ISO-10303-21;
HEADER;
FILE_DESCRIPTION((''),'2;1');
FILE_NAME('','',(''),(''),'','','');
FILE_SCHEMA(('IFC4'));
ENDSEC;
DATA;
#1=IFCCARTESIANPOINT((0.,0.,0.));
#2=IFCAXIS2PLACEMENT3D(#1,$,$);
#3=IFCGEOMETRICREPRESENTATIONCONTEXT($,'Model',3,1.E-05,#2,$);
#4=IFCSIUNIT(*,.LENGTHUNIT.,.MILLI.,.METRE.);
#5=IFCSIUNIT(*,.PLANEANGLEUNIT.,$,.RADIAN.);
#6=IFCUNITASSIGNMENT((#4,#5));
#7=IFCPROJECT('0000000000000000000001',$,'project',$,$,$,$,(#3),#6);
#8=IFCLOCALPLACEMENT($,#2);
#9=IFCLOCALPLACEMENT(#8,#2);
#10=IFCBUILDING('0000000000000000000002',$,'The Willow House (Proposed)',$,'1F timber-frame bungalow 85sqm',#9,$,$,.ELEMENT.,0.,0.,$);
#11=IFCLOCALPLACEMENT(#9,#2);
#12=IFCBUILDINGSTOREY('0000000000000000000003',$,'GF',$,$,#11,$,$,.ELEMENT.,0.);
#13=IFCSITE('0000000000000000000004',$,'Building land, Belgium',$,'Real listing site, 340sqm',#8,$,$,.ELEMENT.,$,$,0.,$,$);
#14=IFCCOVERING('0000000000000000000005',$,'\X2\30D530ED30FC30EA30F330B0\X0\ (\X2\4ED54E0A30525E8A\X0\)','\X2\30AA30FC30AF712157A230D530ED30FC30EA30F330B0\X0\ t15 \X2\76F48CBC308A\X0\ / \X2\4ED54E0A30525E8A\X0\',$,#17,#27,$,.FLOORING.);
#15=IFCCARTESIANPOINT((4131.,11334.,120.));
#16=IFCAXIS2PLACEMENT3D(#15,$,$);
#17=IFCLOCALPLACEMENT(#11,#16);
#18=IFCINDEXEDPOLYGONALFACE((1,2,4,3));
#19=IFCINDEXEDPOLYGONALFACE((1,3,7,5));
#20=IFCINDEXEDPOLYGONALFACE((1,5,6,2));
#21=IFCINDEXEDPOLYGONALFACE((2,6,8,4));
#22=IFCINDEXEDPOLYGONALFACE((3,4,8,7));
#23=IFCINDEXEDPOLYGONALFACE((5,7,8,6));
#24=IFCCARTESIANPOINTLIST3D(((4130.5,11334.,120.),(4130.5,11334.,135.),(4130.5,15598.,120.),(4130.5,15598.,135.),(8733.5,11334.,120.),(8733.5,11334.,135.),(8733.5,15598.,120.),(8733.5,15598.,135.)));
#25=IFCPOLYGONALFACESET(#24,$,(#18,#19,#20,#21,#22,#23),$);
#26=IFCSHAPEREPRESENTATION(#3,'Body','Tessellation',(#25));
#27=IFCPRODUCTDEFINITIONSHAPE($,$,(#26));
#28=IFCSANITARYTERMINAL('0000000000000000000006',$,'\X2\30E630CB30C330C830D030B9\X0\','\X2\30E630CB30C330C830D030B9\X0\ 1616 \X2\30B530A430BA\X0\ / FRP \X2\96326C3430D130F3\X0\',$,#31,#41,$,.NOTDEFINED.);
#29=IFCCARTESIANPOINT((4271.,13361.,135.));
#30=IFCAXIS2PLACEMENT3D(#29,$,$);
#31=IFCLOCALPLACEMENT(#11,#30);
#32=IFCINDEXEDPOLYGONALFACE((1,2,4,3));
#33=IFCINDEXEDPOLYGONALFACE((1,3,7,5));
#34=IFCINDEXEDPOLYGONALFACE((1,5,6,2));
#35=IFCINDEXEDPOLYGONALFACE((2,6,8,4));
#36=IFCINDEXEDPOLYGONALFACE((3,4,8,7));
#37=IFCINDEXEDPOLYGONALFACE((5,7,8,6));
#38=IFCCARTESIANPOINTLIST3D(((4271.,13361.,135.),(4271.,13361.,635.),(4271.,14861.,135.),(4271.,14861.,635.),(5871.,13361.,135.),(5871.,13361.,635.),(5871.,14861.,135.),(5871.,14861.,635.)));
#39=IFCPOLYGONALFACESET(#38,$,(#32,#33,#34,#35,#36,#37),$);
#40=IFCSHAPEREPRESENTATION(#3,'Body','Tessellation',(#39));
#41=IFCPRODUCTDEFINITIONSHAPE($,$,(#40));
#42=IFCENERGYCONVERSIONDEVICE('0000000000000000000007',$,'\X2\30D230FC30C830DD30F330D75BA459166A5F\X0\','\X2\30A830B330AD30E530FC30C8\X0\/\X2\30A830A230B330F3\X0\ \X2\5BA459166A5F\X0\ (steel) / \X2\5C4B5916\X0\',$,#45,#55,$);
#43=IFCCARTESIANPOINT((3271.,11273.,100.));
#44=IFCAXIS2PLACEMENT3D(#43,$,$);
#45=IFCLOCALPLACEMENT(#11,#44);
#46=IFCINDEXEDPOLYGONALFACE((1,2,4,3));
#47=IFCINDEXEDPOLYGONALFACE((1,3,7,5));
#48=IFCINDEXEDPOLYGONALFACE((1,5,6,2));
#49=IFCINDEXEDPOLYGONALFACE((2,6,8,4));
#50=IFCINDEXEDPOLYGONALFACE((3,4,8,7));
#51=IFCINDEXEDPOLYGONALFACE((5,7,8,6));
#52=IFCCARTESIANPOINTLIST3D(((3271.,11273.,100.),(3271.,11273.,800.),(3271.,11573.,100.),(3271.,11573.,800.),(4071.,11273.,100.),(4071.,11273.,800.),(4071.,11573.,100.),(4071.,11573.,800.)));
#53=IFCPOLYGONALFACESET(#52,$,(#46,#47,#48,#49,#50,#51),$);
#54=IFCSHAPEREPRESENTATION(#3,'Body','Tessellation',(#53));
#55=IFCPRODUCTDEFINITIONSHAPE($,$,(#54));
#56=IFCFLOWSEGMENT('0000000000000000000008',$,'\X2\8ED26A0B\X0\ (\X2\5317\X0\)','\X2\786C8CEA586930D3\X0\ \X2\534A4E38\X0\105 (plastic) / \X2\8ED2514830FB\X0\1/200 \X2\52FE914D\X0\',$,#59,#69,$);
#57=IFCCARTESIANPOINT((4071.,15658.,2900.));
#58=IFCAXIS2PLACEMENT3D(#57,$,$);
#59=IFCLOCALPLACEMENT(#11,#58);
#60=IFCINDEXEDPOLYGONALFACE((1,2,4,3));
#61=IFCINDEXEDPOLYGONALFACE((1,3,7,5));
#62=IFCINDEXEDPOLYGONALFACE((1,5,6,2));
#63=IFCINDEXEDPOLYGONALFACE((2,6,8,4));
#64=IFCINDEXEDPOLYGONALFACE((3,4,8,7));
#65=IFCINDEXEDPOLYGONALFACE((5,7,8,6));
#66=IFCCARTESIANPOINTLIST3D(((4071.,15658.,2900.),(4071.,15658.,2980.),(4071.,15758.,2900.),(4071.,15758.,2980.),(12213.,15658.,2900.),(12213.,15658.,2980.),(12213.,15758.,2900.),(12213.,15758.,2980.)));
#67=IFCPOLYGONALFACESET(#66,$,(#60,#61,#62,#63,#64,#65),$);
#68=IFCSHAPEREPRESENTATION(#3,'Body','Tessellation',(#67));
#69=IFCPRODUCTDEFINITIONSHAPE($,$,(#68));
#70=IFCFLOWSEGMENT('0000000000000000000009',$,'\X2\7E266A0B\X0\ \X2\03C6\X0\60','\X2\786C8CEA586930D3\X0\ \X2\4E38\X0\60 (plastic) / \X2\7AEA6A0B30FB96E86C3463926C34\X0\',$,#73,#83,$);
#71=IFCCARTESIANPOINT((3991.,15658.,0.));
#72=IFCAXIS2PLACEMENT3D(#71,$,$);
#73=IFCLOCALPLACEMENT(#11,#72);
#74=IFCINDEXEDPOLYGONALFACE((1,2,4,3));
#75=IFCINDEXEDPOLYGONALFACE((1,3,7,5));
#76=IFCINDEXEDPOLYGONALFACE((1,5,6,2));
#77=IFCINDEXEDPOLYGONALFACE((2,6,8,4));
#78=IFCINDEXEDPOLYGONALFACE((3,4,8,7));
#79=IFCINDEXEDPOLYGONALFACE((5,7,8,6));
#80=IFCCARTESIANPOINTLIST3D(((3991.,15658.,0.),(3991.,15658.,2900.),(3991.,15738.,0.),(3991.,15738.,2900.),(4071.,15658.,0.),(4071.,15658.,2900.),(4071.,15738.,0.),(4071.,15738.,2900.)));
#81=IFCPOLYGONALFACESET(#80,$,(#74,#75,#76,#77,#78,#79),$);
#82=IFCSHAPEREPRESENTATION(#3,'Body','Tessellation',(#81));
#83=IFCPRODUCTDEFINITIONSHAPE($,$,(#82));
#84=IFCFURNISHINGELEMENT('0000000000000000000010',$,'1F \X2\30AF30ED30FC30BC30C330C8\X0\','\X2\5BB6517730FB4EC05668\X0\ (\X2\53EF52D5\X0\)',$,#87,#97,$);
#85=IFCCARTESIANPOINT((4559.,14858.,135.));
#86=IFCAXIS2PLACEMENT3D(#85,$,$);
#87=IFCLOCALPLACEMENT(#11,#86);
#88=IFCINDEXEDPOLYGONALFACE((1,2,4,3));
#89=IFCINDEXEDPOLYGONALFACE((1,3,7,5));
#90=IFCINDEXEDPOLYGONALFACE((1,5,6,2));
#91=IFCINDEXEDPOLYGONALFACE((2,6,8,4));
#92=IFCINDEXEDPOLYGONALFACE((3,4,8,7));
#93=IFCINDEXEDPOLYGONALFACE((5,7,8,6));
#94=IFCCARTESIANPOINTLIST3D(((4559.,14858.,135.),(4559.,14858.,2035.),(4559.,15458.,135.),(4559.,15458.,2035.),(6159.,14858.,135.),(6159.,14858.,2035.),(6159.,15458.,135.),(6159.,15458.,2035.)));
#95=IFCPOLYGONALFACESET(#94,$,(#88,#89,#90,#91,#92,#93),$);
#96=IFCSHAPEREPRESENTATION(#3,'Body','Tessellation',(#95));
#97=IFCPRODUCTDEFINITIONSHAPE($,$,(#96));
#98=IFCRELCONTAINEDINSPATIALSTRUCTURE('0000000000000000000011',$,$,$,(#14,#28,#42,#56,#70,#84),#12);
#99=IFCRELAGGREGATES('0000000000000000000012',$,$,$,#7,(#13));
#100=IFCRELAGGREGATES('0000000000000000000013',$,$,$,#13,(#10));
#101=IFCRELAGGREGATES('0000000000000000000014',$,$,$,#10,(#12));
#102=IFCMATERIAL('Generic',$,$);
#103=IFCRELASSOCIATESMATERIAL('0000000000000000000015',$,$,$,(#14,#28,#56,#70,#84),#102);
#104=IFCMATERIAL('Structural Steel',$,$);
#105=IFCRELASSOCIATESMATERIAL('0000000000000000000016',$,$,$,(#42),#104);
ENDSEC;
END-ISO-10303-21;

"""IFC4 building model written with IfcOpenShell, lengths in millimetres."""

from ifc_helpers import new_model, si_unit, frame, frame_2d, origin, place, context, project, spatial, rectangle, extrude, material, element, save


model = new_model("IFC4")

# Units and contexts
model_context = context("Model", 3, precision=1e-05, world=origin())
ifc_project = project(units=[si_unit("LENGTHUNIT", "METRE", prefix="MILLI"), si_unit("PLANEANGLEUNIT", "RADIAN")], contexts=[model_context])

# Site, building, storey
site_placement = place(None, origin())
site = spatial("IfcSite", under=ifc_project, at=site_placement, Name="Building land, Belgium", ObjectType="Real listing site, 340sqm", CompositionType="ELEMENT", RefElevation=0.0)
building_placement = place(site_placement, origin())
building = spatial("IfcBuilding", under=site, at=building_placement, Name="The Willow House (Proposed)", ObjectType="1F timber-frame bungalow 85sqm", CompositionType="ELEMENT", ElevationOfRefHeight=0.0, ElevationOfTerrain=0.0)
storey_placement = place(building_placement, origin())
storey = spatial("IfcBuildingStorey", under=building, at=storey_placement, Name="GF", CompositionType="ELEMENT", Elevation=0.0)

# Shared definitions
ifc_material_1 = material(Name="Structural Steel")

# Covering
ifc_material_2 = material(Name="Generic")
covering_placement = place(storey_placement, frame((4131.0, 11334.0, 120.0)))
element("IfcCovering", 1, at=covering_placement, inside=storey, material=ifc_material_2, Name="フローリング (仕上げ床)", Description="オーク無垢フローリング t15 直貼り / 仕上げ床", PredefinedType="FLOORING", context=model_context, shape_type="SweptSolid", body=[
    extrude(rectangle(XDim=4603.0, YDim=4264.0, at=frame_2d((2301.0, 2132.0))), frame((4131.0, 11334.0, 120.0)), (0.0, 0.0, 1.0), 15.0),
])

# Sanitary terminal
sanitary_terminal_placement = place(storey_placement, frame((4271.0, 13361.0, 135.0)))
element("IfcSanitaryTerminal", 2, at=sanitary_terminal_placement, inside=storey, material=ifc_material_2, Name="ユニットバス", Description="ユニットバス 1616 サイズ / FRP 防水パン", PredefinedType="NOTDEFINED", context=model_context, shape_type="SweptSolid", body=[
    extrude(rectangle(XDim=1600.0, YDim=1500.0, at=frame_2d((800.0, 750.0))), frame((4271.0, 13361.0, 135.0)), (0.0, 0.0, 1.0), 500.0),
])

# Energy conversion device
energy_conversion_device_placement = place(storey_placement, frame((3271.0, 11273.0, 100.0)))
element("IfcEnergyConversionDevice", 3, at=energy_conversion_device_placement, inside=storey, material=ifc_material_1, Name="ヒートポンプ室外機", Description="エコキュート/エアコン 室外機 (steel) / 屋外", context=model_context, shape_type="SweptSolid", body=[
    extrude(rectangle(XDim=800.0, YDim=300.0, at=frame_2d((400.0, 150.0))), frame((3271.0, 11273.0, 100.0)), (0.0, 0.0, 1.0), 700.0),
])

# Flow segments
flow_segment_1_placement = place(storey_placement, frame((4071.0, 15658.0, 2900.0)))
element("IfcFlowSegment", 4, at=flow_segment_1_placement, inside=storey, material=ifc_material_2, Name="軒樋 (北)", Description="硬質塩ビ 半丸105 (plastic) / 軒先・1/200 勾配", context=model_context, shape_type="SweptSolid", body=[
    extrude(rectangle(XDim=8142.0, YDim=100.0, at=frame_2d((4071.0, 50.0))), frame((4071.0, 15658.0, 2900.0)), (0.0, 0.0, 1.0), 80.0),
])
flow_segment_2_placement = place(storey_placement, frame((3991.0, 15658.0, 0.0)))
element("IfcFlowSegment", 5, at=flow_segment_2_placement, inside=storey, material=ifc_material_2, Name="縦樋 φ60", Description="硬質塩ビ 丸60 (plastic) / 竪樋・雨水排水", context=model_context, shape_type="SweptSolid", body=[
    extrude(rectangle(XDim=80.0, YDim=80.0, at=frame_2d((40.0, 40.0))), frame((3991.0, 15658.0, 0.0)), (0.0, 0.0, 1.0), 2900.0),
])

# Furnishing element
furnishing_placement = place(storey_placement, frame((4559.0, 14858.0, 135.0)))
element("IfcFurnishingElement", 6, at=furnishing_placement, inside=storey, material=ifc_material_2, Name="1F クローゼット", Description="家具・什器 (可動)", context=model_context, shape_type="SweptSolid", body=[
    extrude(rectangle(XDim=1600.0, YDim=600.0, at=frame_2d((800.0, 300.0))), frame((4559.0, 14858.0, 135.0)), (0.0, 0.0, 1.0), 1900.0),
])

save(model, "model.ifc")
